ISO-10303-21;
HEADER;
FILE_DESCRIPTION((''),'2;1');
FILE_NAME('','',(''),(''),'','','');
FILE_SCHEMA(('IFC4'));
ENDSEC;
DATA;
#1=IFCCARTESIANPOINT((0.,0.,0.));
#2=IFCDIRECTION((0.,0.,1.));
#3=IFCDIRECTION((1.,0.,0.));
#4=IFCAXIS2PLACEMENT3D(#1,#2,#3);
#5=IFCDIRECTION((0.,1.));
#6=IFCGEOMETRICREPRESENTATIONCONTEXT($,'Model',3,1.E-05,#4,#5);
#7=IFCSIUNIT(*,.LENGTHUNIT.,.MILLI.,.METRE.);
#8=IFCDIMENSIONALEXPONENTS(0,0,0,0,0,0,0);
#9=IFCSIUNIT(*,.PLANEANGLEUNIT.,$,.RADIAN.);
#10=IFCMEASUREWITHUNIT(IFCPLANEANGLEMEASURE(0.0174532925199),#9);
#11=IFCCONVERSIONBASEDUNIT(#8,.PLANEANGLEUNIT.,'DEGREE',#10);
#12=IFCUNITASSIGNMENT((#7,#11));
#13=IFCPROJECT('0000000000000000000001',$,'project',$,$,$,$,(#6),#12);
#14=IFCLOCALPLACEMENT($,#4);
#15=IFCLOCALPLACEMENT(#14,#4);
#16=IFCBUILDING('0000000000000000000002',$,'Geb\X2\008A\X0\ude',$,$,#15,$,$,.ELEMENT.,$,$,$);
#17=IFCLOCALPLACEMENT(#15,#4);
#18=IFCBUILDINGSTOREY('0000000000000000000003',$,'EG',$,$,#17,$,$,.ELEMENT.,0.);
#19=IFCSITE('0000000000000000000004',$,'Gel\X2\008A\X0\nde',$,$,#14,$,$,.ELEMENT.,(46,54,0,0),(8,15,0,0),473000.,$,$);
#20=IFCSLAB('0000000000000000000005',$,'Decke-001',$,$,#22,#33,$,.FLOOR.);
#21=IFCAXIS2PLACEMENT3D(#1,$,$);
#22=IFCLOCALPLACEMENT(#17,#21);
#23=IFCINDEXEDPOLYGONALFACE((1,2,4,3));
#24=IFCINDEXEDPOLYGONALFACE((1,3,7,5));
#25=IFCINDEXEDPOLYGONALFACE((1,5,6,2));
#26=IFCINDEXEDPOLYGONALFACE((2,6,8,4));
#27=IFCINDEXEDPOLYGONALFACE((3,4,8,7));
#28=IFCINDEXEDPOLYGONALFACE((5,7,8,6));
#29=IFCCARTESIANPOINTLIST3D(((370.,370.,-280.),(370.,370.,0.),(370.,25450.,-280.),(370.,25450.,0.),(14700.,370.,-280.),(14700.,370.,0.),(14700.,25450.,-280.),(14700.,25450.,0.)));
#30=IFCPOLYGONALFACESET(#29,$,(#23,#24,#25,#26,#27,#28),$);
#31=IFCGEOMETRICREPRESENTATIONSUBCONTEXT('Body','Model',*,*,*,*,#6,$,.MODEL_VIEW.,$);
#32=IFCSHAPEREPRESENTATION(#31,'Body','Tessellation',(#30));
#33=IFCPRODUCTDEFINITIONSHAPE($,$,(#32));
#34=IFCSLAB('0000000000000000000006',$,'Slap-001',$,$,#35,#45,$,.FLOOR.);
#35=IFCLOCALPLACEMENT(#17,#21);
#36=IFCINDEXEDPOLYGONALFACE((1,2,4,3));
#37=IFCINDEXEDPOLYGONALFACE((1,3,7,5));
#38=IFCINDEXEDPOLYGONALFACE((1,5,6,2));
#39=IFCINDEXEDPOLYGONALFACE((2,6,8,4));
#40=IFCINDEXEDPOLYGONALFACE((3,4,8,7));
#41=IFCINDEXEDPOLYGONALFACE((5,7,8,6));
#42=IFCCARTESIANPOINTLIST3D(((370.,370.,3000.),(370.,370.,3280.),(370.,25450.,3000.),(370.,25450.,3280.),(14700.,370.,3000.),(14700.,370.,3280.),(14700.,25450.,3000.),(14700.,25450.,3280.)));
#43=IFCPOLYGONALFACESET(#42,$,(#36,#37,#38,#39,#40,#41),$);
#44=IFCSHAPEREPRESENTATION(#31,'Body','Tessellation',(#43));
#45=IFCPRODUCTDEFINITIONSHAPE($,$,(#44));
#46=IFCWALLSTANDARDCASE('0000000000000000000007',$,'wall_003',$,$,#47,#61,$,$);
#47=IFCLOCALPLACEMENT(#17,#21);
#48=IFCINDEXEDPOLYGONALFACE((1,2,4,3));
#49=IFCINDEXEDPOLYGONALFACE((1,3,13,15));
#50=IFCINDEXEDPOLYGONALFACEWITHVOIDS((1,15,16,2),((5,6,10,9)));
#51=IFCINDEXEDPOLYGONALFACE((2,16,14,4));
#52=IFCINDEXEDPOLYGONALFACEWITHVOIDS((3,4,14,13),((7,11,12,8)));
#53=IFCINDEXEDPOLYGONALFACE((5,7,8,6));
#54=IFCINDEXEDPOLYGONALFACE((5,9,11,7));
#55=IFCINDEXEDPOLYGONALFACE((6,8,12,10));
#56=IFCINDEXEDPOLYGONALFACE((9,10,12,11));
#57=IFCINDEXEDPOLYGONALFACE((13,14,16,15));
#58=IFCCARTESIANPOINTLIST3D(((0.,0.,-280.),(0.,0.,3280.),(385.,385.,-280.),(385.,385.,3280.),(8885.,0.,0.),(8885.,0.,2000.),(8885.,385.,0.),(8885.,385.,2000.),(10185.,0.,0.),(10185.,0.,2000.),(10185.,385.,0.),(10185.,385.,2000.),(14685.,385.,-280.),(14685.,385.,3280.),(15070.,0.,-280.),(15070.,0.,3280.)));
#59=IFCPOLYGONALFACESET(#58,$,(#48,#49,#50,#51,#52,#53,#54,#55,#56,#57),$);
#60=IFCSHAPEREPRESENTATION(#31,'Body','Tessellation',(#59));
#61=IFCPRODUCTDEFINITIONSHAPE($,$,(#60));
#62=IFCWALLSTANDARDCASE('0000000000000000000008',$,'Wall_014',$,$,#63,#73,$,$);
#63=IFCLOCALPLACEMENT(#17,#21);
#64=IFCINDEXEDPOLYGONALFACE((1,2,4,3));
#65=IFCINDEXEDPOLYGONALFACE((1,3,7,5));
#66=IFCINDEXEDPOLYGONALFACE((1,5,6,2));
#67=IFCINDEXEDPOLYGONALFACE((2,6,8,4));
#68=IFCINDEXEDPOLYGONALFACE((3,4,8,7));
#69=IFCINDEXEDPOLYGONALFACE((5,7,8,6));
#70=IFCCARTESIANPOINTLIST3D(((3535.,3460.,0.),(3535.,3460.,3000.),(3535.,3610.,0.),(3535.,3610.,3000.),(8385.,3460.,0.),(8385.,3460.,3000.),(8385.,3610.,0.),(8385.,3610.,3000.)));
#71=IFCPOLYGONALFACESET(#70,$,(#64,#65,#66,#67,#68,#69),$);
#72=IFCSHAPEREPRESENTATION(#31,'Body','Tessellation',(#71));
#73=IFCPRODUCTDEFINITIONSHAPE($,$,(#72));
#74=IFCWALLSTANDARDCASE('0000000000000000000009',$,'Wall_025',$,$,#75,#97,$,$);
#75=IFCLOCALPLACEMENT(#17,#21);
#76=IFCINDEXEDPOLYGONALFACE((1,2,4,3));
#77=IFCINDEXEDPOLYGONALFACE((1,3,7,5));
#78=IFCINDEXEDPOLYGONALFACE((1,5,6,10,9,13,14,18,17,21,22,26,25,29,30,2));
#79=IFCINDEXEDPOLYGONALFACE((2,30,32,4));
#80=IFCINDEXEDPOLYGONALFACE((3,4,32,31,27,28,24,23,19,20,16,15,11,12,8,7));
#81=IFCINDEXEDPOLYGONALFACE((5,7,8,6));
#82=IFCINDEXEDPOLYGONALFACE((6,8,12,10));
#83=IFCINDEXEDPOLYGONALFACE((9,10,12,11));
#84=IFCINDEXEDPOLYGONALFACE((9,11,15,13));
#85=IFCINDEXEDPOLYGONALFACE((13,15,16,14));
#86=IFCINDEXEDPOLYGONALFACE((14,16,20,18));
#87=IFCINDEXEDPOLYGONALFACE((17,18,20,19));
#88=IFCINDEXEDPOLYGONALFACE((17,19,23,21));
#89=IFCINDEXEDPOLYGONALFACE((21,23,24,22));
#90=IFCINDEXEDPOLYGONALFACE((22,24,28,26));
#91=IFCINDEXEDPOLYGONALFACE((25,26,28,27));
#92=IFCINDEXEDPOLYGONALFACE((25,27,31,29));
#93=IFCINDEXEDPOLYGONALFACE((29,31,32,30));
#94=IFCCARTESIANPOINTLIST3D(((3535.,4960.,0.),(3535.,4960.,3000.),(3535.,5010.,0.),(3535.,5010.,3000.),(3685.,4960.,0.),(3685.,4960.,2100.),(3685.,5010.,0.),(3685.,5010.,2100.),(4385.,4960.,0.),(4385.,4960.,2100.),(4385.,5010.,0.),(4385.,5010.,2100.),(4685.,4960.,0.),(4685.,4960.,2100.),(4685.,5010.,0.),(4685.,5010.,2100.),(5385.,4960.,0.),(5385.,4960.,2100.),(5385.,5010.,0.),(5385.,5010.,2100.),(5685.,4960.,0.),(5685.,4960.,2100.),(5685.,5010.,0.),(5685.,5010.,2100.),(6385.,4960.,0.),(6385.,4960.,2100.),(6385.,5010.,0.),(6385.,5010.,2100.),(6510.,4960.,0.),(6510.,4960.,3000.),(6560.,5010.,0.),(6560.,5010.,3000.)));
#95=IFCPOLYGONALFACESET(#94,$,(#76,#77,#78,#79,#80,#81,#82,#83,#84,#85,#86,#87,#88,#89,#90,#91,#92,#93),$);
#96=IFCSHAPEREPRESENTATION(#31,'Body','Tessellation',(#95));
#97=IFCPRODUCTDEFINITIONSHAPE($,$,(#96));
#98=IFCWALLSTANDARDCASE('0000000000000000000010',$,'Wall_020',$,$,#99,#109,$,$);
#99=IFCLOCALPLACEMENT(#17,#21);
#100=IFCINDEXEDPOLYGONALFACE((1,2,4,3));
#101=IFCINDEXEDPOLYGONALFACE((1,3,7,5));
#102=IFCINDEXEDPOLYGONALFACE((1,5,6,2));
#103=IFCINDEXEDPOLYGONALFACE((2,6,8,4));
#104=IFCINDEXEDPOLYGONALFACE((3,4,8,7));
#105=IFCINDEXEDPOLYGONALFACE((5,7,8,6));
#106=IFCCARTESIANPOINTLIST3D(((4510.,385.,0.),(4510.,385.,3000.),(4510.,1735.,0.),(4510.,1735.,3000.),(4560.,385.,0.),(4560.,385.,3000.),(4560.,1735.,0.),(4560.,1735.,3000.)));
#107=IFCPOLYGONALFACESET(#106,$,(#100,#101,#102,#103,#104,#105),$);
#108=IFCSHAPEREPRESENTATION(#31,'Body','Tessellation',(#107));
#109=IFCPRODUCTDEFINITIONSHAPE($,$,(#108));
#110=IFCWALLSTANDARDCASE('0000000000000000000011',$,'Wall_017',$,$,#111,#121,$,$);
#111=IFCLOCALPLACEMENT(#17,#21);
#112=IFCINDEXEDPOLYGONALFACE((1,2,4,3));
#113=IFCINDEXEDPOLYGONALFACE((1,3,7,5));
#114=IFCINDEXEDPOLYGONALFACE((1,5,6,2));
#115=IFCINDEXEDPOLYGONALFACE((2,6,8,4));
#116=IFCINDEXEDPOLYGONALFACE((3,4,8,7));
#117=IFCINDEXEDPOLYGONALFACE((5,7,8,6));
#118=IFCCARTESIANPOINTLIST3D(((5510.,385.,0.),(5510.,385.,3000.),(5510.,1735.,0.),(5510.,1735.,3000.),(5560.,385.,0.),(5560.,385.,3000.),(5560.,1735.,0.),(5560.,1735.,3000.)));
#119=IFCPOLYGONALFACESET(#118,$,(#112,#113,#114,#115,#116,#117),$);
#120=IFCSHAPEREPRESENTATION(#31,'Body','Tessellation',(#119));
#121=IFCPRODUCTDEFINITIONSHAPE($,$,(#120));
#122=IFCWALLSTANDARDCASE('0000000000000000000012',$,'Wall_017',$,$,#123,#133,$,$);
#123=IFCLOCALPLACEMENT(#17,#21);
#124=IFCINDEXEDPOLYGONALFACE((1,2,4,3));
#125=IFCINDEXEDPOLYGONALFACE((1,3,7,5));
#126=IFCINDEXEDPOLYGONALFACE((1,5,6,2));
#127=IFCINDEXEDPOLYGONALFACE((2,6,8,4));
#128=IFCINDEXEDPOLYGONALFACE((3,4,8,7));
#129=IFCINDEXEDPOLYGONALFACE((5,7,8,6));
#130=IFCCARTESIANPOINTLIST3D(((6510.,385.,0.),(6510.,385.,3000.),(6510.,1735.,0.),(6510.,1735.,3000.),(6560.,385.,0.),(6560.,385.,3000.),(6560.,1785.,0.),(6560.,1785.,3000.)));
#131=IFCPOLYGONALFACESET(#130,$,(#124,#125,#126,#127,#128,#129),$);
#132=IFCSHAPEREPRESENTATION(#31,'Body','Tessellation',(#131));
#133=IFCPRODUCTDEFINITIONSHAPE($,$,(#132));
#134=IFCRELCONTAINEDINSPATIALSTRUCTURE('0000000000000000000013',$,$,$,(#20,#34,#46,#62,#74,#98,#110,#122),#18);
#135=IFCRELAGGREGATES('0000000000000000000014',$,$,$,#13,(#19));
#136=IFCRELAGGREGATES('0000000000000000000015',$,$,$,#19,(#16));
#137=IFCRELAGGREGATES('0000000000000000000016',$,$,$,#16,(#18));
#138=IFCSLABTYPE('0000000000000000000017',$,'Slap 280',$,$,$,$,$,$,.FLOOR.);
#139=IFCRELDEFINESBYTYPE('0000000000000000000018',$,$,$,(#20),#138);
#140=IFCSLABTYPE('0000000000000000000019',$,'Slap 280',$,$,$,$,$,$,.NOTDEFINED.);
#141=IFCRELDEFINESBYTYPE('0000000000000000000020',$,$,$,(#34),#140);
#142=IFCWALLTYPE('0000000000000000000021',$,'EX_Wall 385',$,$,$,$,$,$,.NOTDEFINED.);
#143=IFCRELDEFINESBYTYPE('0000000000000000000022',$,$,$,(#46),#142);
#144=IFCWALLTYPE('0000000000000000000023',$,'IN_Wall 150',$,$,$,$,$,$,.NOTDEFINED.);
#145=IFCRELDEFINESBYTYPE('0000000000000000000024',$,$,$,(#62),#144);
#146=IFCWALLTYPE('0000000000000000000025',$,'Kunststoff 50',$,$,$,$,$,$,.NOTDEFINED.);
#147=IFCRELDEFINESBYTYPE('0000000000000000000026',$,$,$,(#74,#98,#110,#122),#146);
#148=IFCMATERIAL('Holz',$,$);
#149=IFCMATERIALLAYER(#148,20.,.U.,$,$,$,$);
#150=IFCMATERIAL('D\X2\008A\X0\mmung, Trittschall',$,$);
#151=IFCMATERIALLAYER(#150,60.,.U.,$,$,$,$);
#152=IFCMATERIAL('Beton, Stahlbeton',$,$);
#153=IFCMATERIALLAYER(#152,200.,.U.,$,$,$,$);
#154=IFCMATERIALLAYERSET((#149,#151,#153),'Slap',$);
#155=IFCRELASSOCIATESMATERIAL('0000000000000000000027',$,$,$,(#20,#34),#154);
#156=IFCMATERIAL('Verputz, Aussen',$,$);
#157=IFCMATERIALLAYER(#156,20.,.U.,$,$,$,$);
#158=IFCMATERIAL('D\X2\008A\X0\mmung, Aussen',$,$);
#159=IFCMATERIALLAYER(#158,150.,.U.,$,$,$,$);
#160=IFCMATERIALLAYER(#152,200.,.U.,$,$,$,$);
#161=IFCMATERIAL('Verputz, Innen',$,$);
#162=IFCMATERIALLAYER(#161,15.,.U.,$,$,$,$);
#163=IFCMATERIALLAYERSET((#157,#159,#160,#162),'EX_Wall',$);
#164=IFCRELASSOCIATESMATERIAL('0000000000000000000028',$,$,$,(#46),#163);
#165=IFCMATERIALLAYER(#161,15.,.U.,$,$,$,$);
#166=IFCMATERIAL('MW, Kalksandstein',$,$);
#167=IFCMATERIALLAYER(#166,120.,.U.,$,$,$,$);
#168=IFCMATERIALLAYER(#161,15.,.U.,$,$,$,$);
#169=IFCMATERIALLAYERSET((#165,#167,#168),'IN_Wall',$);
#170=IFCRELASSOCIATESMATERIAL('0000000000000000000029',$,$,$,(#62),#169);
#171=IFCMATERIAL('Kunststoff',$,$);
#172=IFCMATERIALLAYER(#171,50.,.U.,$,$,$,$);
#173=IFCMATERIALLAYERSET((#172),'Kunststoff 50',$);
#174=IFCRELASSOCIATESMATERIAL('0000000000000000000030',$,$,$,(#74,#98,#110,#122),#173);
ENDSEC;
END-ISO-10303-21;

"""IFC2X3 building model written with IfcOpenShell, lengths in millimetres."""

from ifc_helpers import new_model, entity, si_unit, converted_unit, direction, frame, origin_with_axes, origin_2d_with_axis, place, context, subcontext, project, spatial, polyline, rectangle, outline, extrude, material, layer, layer_set, layer_usage, type_object, element, save


model = new_model("IFC2X3")

# Units and contexts
model_context = context("Model", 3, precision=1e-05, world=origin_with_axes(), true_north=direction((0.0, 1.0)))
body_context = subcontext(model_context, "Body", "Model", "MODEL_VIEW")
ifc_project = project(units=[si_unit("LENGTHUNIT", "METRE", prefix="MILLI"), converted_unit("PLANEANGLEUNIT", "DEGREE", entity("IfcPlaneAngleMeasure", 0.0174532925199), si_unit("PLANEANGLEUNIT", "RADIAN"), dimensions=[0, 0, 0, 0, 0, 0, 0])], contexts=[model_context])

# Site, building, storey
site_placement = place(None, origin_with_axes())
site = spatial("IfcSite", under=ifc_project, at=site_placement, Name="Gel\u008ande", CompositionType="ELEMENT", RefLatitude=(46, 54, 0, 0), RefLongitude=(8, 15, 0, 0), RefElevation=473000.0)
building_placement = place(site_placement, origin_with_axes())
building = spatial("IfcBuilding", under=site, at=building_placement, Name="Geb\u008aude", CompositionType="ELEMENT")
storey_placement = place(building_placement, origin_with_axes())
storey = spatial("IfcBuildingStorey", under=building, at=storey_placement, Name="EG", CompositionType="ELEMENT", Elevation=0.0)

# Slabs
ifc_material_1 = material(Name="Holz")
ifc_layer_1 = layer(ifc_material_1, 20.0, ventilated="UNKNOWN")
ifc_material_2 = material(Name="D\u008ammung, Trittschall")
ifc_layer_2 = layer(ifc_material_2, 60.0, ventilated="UNKNOWN")
ifc_material_3 = material(Name="Beton, Stahlbeton")
ifc_layer_3 = layer(ifc_material_3, 200.0, ventilated="UNKNOWN")
ifc_layer_set_1 = layer_set([ifc_layer_1, ifc_layer_2, ifc_layer_3], Name="Slap")
ifc_layer_usage_1 = layer_usage(ifc_layer_set_1, "AXIS3", "NEGATIVE", 280.0)
slab_type_1 = type_object("IfcSlabType", Name="Slap 280", PredefinedType="FLOOR")
slab_1_placement = place(storey_placement, frame((370.0, 370.0, 0.0), z_axis=(0.0, 0.0, 1.0), x_axis=(1.0, 0.0, 0.0)))
element("IfcSlab", 1, at=slab_1_placement, inside=storey, type_object=slab_type_1, material=ifc_layer_usage_1, Name="Decke-001", PredefinedType="FLOOR", context=body_context, shape_type="SweptSolid", body=[
    extrude(outline(polyline([(0.0, 0.0), (14330.0, 0.0), (14330.0, 25080.0), (0.0, 25080.0), (0.0, 0.0)])), frame((0.0, 0.0, -280.0), z_axis=(0.0, 0.0, 1.0), x_axis=(1.0, 0.0, 0.0)), (0.0, 0.0, 1.0), 280.0),
])
ifc_layer_usage_2 = layer_usage(ifc_layer_set_1, "AXIS3", "NEGATIVE", 280.0)
slab_type_2 = type_object("IfcSlabType", Name="Slap 280", PredefinedType="NOTDEFINED")
slab_2_placement = place(storey_placement, frame((370.0, 370.0, 3280.0), z_axis=(0.0, 0.0, 1.0), x_axis=(1.0, 0.0, 0.0)))
element("IfcSlab", 2, at=slab_2_placement, inside=storey, type_object=slab_type_2, material=ifc_layer_usage_2, Name="Slap-001", PredefinedType="FLOOR", context=body_context, shape_type="SweptSolid", body=[
    extrude(outline(polyline([(0.0, 0.0), (14330.0, 0.0), (14330.0, 25080.0), (0.0, 25080.0), (0.0, 0.0)])), frame((0.0, 0.0, -280.0), z_axis=(0.0, 0.0, 1.0), x_axis=(1.0, 0.0, 0.0)), (0.0, 0.0, 1.0), 280.0),
])

# Wall, opening
ifc_material_4 = material(Name="Verputz, Aussen")
ifc_layer_4 = layer(ifc_material_4, 20.0, ventilated="UNKNOWN")
ifc_material_5 = material(Name="D\u008ammung, Aussen")
ifc_layer_5 = layer(ifc_material_5, 150.0, ventilated="UNKNOWN")
ifc_layer_6 = layer(ifc_material_3, 200.0, ventilated="UNKNOWN")
ifc_material_6 = material(Name="Verputz, Innen")
ifc_layer_7 = layer(ifc_material_6, 15.0, ventilated="UNKNOWN")
ifc_layer_set_2 = layer_set([ifc_layer_4, ifc_layer_5, ifc_layer_6, ifc_layer_7], Name="EX_Wall")
ifc_layer_usage_3 = layer_usage(ifc_layer_set_2, "AXIS2", "POSITIVE", 0.0)
wall_type_1 = type_object("IfcWallType", Name="EX_Wall 385", PredefinedType="NOTDEFINED")
wall_1_placement = place(storey_placement, frame((385.0, 0.0, -280.0), z_axis=(0.0, 0.0, 1.0), x_axis=(1.0, 0.0, 0.0)))
wall_1 = element("IfcWallStandardCase", 3, at=wall_1_placement, inside=storey, type_object=wall_type_1, material=ifc_layer_usage_3, Name="wall_003", context=body_context, shape_type="SweptSolid", body=[
    extrude(outline(polyline([(-385.0, 0.0), (14685.0, 0.0), (14300.0, 385.0), (0.0, 385.0), (-385.0, 0.0)])), origin_with_axes(), (0.0, 0.0, 1.0), 3560.0),
])
opening_1_placement = place(wall_1_placement, frame((9150.0, 0.0, 280.0), z_axis=(0.0, 0.0, 1.0), x_axis=(1.0, 0.0, 0.0)))
element("IfcOpeningElement", 4, at=opening_1_placement, cuts=wall_1, context=body_context, shape_type="SweptSolid", body=[
    extrude(rectangle(XDim=1300.0, YDim=2000.0, at=origin_2d_with_axis()), frame((0.0, 385.0, 1000.0), z_axis=(0.0, -1.0, 0.0), x_axis=(1.0, 0.0, 0.0)), (0.0, 0.0, 1.0), 1155.0),
])

# Wall
ifc_layer_8 = layer(ifc_material_6, 15.0, ventilated="UNKNOWN")
ifc_material_7 = material(Name="MW, Kalksandstein")
ifc_layer_9 = layer(ifc_material_7, 120.0, ventilated="UNKNOWN")
ifc_layer_10 = layer(ifc_material_6, 15.0, ventilated="UNKNOWN")
ifc_layer_set_3 = layer_set([ifc_layer_8, ifc_layer_9, ifc_layer_10], Name="IN_Wall")
wall_type_2 = type_object("IfcWallType", Name="IN_Wall 150", PredefinedType="NOTDEFINED")
ifc_layer_usage_4 = layer_usage(ifc_layer_set_3, "AXIS2", "POSITIVE", -75.0)
wall_2_placement = place(storey_placement, frame((3385.0, 3535.0, 0.0), z_axis=(0.0, 0.0, 1.0), x_axis=(1.0, 0.0, 0.0)))
element("IfcWallStandardCase", 5, at=wall_2_placement, inside=storey, type_object=wall_type_2, material=ifc_layer_usage_4, Name="Wall_014", context=body_context, shape_type="SweptSolid", body=[
    extrude(outline(polyline([(150.0, -75.0), (5000.0, -75.0), (5000.0, 75.0), (150.0, 75.0), (150.0, -75.0)])), origin_with_axes(), (0.0, 0.0, 1.0), 3000.0),
])
ifc_material_8 = material(Name="Kunststoff")
ifc_layer_11 = layer(ifc_material_8, 50.0, ventilated="UNKNOWN")
ifc_layer_set_4 = layer_set([ifc_layer_11], Name="Kunststoff 50")
wall_type_3 = type_object("IfcWallType", Name="Kunststoff 50", PredefinedType="NOTDEFINED")

# Wall, openings
ifc_layer_usage_5 = layer_usage(ifc_layer_set_4, "AXIS2", "POSITIVE", -25.0)
wall_3_placement = place(storey_placement, frame((6535.0, 4985.0, 0.0), z_axis=(0.0, 0.0, 1.0), x_axis=(-1.0, 0.0, 0.0)))
wall_3 = element("IfcWallStandardCase", 6, at=wall_3_placement, inside=storey, type_object=wall_type_3, material=ifc_layer_usage_5, Name="Wall_025", context=body_context, shape_type="SweptSolid", body=[
    extrude(outline(polyline([(-25.0, -25.0), (3000.0, -25.0), (3000.0, 25.0), (25.0, 25.0), (-25.0, -25.0)])), origin_with_axes(), (0.0, 0.0, 1.0), 3000.0),
])
opening_2_placement = place(wall_3_placement, frame((2500.0, 0.0, 0.0), z_axis=(0.0, 0.0, 1.0), x_axis=(1.0, 0.0, 0.0)))
element("IfcOpeningElement", 7, at=opening_2_placement, cuts=wall_3, context=body_context, shape_type="SweptSolid", body=[
    extrude(rectangle(XDim=700.0, YDim=2100.0, at=origin_2d_with_axis()), frame((0.0, -50.0, 1050.0), z_axis=(0.0, -1.0, 0.0), x_axis=(-1.0, 0.0, 0.0)), (0.0, 0.0, -1.0), 150.0),
])
opening_3_placement = place(wall_3_placement, frame((1500.0, 0.0, 0.0), z_axis=(0.0, 0.0, 1.0), x_axis=(1.0, 0.0, 0.0)))
element("IfcOpeningElement", 8, at=opening_3_placement, cuts=wall_3, context=body_context, shape_type="SweptSolid", body=[
    extrude(rectangle(XDim=700.0, YDim=2100.0, at=origin_2d_with_axis()), frame((0.0, -50.0, 1050.0), z_axis=(0.0, -1.0, 0.0), x_axis=(-1.0, 0.0, 0.0)), (0.0, 0.0, -1.0), 150.0),
])
opening_4_placement = place(wall_3_placement, frame((500.0, 0.0, 0.0), z_axis=(0.0, 0.0, 1.0), x_axis=(1.0, 0.0, 0.0)))
element("IfcOpeningElement", 9, at=opening_4_placement, cuts=wall_3, context=body_context, shape_type="SweptSolid", body=[
    extrude(rectangle(XDim=700.0, YDim=2100.0, at=origin_2d_with_axis()), frame((0.0, -50.0, 1050.0), z_axis=(0.0, -1.0, 0.0), x_axis=(-1.0, 0.0, 0.0)), (0.0, 0.0, -1.0), 150.0),
])

# Walls
ifc_layer_usage_6 = layer_usage(ifc_layer_set_4, "AXIS2", "POSITIVE", -25.0)
wall_4_placement = place(storey_placement, frame((4535.0, 385.0, 0.0), z_axis=(0.0, 0.0, 1.0), x_axis=(0.0, 1.0, 0.0)))
element("IfcWallStandardCase", 10, at=wall_4_placement, inside=storey, type_object=wall_type_3, material=ifc_layer_usage_6, Name="Wall_020", context=body_context, shape_type="SweptSolid", body=[
    extrude(outline(polyline([(0.0, -25.0), (1350.0, -25.0), (1350.0, 25.0), (0.0, 25.0), (0.0, -25.0)])), origin_with_axes(), (0.0, 0.0, 1.0), 3000.0),
])
ifc_layer_usage_7 = layer_usage(ifc_layer_set_4, "AXIS2", "POSITIVE", -25.0)
wall_5_placement = place(storey_placement, frame((5535.0, 385.0, 0.0), z_axis=(0.0, 0.0, 1.0), x_axis=(0.0, 1.0, 0.0)))
element("IfcWallStandardCase", 11, at=wall_5_placement, inside=storey, type_object=wall_type_3, material=ifc_layer_usage_7, Name="Wall_017", context=body_context, shape_type="SweptSolid", body=[
    extrude(outline(polyline([(0.0, -25.0), (1350.0, -25.0), (1350.0, 25.0), (0.0, 25.0), (0.0, -25.0)])), origin_with_axes(), (0.0, 0.0, 1.0), 3000.0),
])
ifc_layer_usage_8 = layer_usage(ifc_layer_set_4, "AXIS2", "POSITIVE", -25.0)
wall_6_placement = place(storey_placement, frame((6535.0, 385.0, 0.0), z_axis=(0.0, 0.0, 1.0), x_axis=(0.0, 1.0, 0.0)))
element("IfcWallStandardCase", 12, at=wall_6_placement, inside=storey, type_object=wall_type_3, material=ifc_layer_usage_8, Name="Wall_017", context=body_context, shape_type="SweptSolid", body=[
    extrude(outline(polyline([(0.0, -25.0), (1400.0, -25.0), (1350.0, 25.0), (0.0, 25.0), (0.0, -25.0)])), origin_with_axes(), (0.0, 0.0, 1.0), 3000.0),
])

save(model, "model.ifc")
